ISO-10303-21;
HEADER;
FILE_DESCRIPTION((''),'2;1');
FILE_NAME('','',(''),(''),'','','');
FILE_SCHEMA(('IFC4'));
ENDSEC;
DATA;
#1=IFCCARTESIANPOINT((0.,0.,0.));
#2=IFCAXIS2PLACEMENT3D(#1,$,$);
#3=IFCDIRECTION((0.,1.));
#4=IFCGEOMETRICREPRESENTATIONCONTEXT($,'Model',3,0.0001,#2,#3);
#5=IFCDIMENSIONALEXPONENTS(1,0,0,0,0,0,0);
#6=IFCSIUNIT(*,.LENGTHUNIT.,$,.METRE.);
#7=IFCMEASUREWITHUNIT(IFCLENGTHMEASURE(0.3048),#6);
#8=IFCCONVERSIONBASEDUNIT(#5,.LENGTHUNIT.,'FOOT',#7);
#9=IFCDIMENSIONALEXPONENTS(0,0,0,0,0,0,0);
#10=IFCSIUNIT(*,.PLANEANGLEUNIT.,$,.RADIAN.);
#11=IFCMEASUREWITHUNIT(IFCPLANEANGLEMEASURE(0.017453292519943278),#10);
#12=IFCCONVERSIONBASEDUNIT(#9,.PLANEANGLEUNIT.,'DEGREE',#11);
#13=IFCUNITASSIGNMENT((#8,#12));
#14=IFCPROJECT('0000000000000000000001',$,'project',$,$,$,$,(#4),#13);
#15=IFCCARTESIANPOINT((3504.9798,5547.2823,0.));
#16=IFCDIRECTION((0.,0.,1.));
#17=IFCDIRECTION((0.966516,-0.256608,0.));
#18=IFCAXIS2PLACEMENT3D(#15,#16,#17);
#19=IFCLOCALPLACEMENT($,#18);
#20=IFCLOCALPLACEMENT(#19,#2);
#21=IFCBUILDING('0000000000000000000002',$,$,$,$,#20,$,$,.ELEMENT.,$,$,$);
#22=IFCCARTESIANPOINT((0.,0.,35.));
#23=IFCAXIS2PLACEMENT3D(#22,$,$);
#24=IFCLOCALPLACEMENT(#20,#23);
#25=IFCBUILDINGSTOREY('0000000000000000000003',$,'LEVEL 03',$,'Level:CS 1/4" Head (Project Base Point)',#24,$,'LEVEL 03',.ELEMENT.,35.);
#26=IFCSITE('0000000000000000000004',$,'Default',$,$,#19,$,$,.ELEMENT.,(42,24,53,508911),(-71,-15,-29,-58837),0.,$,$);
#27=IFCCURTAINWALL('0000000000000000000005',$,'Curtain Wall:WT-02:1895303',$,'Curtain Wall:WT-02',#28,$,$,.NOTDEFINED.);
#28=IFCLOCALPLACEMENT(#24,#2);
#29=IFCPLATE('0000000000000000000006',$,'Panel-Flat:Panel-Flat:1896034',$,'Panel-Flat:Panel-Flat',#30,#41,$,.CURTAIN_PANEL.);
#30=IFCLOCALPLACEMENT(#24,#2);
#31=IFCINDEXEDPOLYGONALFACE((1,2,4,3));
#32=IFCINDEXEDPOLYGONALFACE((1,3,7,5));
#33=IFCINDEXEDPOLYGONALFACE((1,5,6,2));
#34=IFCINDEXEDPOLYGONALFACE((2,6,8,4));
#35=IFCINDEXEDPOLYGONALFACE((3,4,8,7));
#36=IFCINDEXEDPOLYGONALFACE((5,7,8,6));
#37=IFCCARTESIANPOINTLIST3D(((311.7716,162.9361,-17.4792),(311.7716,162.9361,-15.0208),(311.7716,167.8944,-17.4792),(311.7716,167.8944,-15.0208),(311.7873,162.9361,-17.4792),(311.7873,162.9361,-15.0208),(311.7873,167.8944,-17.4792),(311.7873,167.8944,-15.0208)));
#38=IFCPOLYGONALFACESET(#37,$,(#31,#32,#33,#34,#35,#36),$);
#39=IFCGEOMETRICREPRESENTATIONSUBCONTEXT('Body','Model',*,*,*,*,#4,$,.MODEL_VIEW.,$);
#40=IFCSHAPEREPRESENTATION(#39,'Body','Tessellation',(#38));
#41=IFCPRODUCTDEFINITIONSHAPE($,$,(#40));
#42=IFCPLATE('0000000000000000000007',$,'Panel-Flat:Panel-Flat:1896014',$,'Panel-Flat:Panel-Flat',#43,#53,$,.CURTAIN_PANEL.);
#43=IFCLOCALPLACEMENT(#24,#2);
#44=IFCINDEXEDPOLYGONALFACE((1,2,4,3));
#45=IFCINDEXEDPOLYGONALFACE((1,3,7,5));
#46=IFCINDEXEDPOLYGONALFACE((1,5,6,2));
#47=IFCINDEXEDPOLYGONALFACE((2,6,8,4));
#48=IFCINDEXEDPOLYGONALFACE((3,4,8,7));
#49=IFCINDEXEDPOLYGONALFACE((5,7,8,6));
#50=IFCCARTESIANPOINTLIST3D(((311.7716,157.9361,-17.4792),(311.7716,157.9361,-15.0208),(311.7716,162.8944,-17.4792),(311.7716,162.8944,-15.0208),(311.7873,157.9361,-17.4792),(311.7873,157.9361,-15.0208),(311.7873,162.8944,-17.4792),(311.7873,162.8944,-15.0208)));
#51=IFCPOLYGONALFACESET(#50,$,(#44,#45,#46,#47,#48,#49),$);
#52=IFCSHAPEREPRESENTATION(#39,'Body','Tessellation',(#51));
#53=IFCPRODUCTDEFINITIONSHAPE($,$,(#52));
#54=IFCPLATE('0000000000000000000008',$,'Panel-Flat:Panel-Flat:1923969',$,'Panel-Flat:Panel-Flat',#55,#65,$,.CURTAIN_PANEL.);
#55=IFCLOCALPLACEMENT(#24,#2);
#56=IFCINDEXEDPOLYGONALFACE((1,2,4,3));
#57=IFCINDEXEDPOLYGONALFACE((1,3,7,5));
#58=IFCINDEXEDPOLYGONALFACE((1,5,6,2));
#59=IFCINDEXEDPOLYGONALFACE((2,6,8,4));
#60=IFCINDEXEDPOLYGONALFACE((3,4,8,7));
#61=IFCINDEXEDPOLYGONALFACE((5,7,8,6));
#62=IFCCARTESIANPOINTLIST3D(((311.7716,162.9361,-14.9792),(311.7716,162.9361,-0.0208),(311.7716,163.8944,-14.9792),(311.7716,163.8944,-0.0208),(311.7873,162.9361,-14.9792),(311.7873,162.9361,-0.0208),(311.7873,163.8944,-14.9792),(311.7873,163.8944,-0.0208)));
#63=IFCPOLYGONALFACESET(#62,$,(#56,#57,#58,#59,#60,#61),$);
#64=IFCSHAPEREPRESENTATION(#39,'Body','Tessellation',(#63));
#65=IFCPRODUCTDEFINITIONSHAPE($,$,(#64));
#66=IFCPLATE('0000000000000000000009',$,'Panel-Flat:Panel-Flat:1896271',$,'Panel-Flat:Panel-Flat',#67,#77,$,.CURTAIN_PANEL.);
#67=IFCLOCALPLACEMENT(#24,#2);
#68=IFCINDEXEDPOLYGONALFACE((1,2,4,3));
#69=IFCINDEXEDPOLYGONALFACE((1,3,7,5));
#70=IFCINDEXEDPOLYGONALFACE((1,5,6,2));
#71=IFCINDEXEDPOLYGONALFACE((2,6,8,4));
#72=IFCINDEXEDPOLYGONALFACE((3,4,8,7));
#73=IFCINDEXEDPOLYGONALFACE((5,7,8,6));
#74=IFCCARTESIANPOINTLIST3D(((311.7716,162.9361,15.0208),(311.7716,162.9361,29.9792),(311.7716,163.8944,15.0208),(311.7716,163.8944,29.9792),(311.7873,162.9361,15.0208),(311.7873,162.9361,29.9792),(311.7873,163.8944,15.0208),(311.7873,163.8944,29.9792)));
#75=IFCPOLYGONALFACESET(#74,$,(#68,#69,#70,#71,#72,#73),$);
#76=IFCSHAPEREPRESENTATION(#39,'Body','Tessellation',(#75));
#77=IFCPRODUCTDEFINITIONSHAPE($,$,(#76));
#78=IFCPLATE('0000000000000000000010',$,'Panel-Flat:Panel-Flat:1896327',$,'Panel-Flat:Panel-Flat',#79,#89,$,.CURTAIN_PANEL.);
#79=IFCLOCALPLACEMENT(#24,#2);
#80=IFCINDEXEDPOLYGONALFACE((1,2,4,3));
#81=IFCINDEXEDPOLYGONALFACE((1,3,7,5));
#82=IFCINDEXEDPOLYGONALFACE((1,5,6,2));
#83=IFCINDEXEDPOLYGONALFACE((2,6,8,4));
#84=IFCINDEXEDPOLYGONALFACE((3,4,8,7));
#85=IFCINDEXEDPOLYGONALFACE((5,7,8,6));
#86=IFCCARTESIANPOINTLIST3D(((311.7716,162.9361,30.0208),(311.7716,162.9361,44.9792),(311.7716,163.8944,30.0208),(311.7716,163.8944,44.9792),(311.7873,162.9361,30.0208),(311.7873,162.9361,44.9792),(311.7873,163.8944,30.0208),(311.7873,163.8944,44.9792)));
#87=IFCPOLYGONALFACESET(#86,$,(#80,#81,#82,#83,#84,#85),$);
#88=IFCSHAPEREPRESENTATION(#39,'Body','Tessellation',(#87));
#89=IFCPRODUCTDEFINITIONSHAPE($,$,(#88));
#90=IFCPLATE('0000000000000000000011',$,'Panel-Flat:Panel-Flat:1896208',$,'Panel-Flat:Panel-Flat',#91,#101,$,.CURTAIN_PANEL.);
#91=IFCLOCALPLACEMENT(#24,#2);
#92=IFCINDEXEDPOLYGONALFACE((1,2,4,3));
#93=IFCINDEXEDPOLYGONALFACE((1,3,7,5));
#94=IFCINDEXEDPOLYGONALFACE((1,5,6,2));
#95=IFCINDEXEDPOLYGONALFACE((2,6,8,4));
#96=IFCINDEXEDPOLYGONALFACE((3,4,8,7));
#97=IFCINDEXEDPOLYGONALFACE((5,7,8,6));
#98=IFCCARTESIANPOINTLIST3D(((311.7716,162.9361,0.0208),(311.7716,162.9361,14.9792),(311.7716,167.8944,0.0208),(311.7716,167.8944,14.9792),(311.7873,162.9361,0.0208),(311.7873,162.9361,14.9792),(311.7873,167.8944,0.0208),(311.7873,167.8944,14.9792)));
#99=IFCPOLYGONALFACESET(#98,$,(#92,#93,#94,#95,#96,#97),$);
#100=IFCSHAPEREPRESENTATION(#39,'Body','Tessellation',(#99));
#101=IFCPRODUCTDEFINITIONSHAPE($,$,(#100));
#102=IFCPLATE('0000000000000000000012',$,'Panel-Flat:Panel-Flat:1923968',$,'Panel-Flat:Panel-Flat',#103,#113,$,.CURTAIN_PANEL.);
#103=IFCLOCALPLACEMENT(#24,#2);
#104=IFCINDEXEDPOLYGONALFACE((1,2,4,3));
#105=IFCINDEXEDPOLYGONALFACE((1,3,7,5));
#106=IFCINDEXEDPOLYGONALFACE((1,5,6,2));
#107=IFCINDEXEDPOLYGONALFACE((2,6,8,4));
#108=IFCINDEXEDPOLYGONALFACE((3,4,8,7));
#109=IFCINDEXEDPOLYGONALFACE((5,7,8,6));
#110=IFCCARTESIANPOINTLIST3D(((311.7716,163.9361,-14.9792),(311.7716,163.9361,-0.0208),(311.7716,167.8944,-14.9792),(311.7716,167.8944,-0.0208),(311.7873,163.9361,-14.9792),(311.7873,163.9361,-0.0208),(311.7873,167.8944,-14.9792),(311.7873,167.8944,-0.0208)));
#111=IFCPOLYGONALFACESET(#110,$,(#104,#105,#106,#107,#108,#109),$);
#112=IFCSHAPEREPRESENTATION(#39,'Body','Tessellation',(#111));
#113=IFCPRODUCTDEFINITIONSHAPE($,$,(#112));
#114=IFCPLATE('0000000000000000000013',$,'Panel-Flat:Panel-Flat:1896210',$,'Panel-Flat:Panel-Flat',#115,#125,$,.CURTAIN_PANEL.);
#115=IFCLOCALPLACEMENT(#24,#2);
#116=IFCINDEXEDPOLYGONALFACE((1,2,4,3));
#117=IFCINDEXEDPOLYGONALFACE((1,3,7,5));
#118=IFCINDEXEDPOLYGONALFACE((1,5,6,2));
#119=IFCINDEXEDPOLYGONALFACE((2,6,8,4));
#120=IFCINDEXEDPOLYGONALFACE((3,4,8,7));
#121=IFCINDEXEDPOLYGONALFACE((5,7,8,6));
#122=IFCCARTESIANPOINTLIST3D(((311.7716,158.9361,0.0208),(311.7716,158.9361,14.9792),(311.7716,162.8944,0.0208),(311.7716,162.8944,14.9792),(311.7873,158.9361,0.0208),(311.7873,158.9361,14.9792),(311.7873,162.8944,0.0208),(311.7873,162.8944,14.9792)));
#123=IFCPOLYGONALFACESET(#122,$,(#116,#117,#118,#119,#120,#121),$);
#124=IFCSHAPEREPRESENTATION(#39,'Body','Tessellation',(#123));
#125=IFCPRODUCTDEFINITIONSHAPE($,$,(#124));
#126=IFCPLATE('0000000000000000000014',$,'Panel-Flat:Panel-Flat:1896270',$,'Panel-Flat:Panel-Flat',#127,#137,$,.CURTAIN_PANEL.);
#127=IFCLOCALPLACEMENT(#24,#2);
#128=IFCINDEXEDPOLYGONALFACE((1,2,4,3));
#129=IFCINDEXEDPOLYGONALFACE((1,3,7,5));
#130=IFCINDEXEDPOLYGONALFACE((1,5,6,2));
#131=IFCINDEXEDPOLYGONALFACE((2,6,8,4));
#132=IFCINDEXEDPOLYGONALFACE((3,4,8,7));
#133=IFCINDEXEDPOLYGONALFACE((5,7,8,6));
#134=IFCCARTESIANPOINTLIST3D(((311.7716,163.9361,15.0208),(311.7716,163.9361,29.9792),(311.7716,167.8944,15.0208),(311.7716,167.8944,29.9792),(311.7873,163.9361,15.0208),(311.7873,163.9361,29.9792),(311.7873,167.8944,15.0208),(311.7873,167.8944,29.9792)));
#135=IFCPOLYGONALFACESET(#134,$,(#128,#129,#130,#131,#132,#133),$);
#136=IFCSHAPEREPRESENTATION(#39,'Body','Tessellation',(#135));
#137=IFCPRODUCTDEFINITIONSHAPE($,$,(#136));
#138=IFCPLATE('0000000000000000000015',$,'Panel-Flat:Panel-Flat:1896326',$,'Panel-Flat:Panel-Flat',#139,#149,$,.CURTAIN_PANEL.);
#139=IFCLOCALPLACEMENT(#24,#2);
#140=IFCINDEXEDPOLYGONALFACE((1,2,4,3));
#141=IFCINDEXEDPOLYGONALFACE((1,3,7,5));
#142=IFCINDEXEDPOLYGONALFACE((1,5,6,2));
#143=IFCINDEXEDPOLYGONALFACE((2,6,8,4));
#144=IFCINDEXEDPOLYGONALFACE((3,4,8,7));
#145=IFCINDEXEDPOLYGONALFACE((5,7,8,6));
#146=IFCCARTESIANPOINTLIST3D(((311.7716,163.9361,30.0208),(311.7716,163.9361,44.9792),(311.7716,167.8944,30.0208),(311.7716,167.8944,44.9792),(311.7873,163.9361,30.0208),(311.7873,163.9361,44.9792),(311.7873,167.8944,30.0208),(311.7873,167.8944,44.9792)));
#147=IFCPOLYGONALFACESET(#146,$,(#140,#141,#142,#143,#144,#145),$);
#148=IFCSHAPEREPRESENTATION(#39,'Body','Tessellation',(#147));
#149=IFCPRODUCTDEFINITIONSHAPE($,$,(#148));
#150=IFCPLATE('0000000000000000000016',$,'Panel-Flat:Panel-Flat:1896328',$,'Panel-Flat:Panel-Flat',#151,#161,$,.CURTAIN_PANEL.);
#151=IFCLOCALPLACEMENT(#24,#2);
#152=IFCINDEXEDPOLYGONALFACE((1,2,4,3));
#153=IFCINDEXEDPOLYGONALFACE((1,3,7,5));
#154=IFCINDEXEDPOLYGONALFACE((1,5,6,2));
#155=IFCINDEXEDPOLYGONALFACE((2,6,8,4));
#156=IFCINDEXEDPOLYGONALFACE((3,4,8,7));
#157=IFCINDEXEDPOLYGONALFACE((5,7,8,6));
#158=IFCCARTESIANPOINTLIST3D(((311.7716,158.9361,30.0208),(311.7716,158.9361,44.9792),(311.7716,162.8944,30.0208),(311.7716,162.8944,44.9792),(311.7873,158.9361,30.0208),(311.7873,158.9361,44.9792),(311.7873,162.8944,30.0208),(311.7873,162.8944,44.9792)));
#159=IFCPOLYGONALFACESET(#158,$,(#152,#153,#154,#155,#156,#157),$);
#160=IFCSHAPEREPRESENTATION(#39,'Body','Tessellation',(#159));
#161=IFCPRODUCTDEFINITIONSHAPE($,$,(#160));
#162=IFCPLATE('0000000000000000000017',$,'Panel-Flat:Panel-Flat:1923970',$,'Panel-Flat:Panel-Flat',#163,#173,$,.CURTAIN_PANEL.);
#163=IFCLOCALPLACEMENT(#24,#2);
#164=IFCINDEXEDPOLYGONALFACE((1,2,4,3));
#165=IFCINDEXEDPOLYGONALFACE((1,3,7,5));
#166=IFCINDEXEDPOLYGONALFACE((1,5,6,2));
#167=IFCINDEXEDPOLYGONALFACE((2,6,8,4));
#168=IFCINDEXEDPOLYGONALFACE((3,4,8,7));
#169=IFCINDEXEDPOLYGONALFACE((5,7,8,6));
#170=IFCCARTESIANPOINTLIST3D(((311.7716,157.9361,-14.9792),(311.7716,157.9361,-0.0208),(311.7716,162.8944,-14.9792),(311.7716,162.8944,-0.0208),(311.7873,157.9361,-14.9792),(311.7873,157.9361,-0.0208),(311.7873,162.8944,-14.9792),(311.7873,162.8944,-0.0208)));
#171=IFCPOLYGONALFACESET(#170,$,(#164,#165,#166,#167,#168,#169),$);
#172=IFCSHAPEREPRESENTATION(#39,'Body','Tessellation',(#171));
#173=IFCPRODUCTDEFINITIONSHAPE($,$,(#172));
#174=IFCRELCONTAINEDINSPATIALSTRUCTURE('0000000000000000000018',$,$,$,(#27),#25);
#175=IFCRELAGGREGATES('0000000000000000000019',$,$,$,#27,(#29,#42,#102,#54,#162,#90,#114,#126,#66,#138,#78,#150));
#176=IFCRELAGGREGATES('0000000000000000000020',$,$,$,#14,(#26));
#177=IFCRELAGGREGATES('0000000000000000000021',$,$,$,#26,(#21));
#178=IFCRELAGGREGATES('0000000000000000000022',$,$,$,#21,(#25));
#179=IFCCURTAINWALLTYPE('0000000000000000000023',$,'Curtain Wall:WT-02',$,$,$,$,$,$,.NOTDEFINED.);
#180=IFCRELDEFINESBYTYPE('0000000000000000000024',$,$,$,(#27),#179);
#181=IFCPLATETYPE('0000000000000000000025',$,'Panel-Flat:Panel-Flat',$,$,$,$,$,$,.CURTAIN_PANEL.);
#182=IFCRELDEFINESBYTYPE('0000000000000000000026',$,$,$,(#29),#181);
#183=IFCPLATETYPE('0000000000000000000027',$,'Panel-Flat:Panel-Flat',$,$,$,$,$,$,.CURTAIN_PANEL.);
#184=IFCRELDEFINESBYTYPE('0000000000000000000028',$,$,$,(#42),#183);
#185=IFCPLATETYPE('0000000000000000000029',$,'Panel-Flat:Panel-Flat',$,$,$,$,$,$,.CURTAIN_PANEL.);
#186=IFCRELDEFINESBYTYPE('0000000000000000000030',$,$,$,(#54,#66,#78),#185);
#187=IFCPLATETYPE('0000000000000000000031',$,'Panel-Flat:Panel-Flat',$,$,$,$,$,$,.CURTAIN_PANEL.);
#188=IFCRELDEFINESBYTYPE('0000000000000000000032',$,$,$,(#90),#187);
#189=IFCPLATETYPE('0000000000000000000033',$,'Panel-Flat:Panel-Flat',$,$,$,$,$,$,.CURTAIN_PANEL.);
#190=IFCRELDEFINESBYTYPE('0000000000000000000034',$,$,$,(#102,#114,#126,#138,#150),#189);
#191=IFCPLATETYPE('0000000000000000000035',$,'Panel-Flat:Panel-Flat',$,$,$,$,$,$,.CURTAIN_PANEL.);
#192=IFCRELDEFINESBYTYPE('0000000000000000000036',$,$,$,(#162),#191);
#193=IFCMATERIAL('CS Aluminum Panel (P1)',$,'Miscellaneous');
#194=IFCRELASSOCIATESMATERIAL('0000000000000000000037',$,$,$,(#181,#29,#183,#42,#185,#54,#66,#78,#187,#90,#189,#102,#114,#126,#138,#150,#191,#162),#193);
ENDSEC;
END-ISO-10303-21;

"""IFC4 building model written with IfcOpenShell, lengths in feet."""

from ifc_helpers import new_model, entity, si_unit, converted_unit, direction, frame, origin, place, context, subcontext, project, spatial, indexed_curve, outline, extrude, source, transform, mapped, material, type_object, type_shapes, element, aggregate, save


model = new_model("IFC4")

# Units and contexts
model_context = context("Model", 3, precision=0.0001, world=origin(), true_north=direction((0.0, 1.0)))
body_context = subcontext(model_context, "Body", "Model", "MODEL_VIEW")
ifc_project = project(units=[converted_unit("LENGTHUNIT", "FOOT", entity("IfcLengthMeasure", 0.3048), si_unit("LENGTHUNIT", "METRE"), dimensions=[1, 0, 0, 0, 0, 0, 0]), converted_unit("PLANEANGLEUNIT", "DEGREE", entity("IfcPlaneAngleMeasure", 0.017453292519943278), si_unit("PLANEANGLEUNIT", "RADIAN"), dimensions=[0, 0, 0, 0, 0, 0, 0])], contexts=[model_context])

# Site, building, storey
site_placement = place(None, frame((3504.9798, 5547.2823, 0.0), z_axis=(0.0, 0.0, 1.0), x_axis=(0.966516, -0.256608, 0.0)))
site = spatial("IfcSite", under=ifc_project, at=site_placement, Name="Default", CompositionType="ELEMENT", RefLatitude=(42, 24, 53, 508911), RefLongitude=(-71, -15, -29, -58837), RefElevation=0.0)
building_placement = place(site_placement, origin())
building = spatial("IfcBuilding", under=site, at=building_placement, CompositionType="ELEMENT")
storey_placement = place(building_placement, frame((0.0, 0.0, 35.0)))
storey = spatial("IfcBuildingStorey", under=building, at=storey_placement, Name="LEVEL 03", ObjectType="Level:CS 1/4\" Head (Project Base Point)", LongName="LEVEL 03", CompositionType="ELEMENT", Elevation=35.0)

# Curtain wall, plates
curtain_wall_type = type_object("IfcCurtainWallType", Name="Curtain Wall:WT-02", PredefinedType="NOTDEFINED")
curtain_wall_placement = place(storey_placement, frame((0.0, 0.0, -35.0)))
curtain_wall = element("IfcCurtainWall", 1, at=curtain_wall_placement, inside=storey, type_object=curtain_wall_type, Name="Curtain Wall:WT-02:1895303", ObjectType="Curtain Wall:WT-02", PredefinedType="NOTDEFINED")
ifc_material_1 = material(Name="CS Aluminum Panel (P1)", Category="Miscellaneous")
plate_type_1 = type_object("IfcPlateType", Name="Panel-Flat:Panel-Flat", PredefinedType="CURTAIN_PANEL", material=ifc_material_1)
shared_shape_1 = source(origin(), body_context, "Body", "SweptSolid", [
    extrude(outline(indexed_curve([(-0.0078, -2.4792), (0.0078, -2.4792), (0.0078, 2.4792), (-0.0078, 2.4792), (-0.0078, -2.4792)], self_intersect=False)), frame((2.4792, 0.0078, 0.0), z_axis=(0.0, 0.0, 1.0), x_axis=(0.0, -1.0, 0.0)), (0.0, 0.0, 1.0), 2.4583),
])
type_shapes(plate_type_1, [shared_shape_1])
plate_1_placement = place(curtain_wall_placement, frame((311.7716, 167.8944, 17.5208), z_axis=(0.0, 0.0, 1.0), x_axis=(0.0, -1.0, 0.0)))
plate_1 = element("IfcPlate", 2, at=plate_1_placement, type_object=plate_type_1, material=ifc_material_1, Name="Panel-Flat:Panel-Flat:1896034", ObjectType="Panel-Flat:Panel-Flat", PredefinedType="CURTAIN_PANEL", context=body_context, shape_type="MappedRepresentation", body=[
    mapped(shared_shape_1, transform((0.0, 0.0, 0.0), scale=1.0)),
])
plate_type_2 = type_object("IfcPlateType", Name="Panel-Flat:Panel-Flat", PredefinedType="CURTAIN_PANEL", material=ifc_material_1)
shared_shape_2 = source(origin(), body_context, "Body", "SweptSolid", [
    extrude(outline(indexed_curve([(-0.0078, -2.4792), (0.0078, -2.4792), (0.0078, 2.4792), (-0.0078, 2.4792), (-0.0078, -2.4792)], self_intersect=False)), frame((2.4792, 0.0078, 0.0), z_axis=(0.0, 0.0, 1.0), x_axis=(0.0, -1.0, 0.0)), (0.0, 0.0, 1.0), 2.4583),
])
type_shapes(plate_type_2, [shared_shape_2])
plate_2_placement = place(curtain_wall_placement, frame((311.7716, 162.8944, 17.5208), z_axis=(0.0, 0.0, 1.0), x_axis=(0.0, -1.0, 0.0)))
plate_2 = element("IfcPlate", 3, at=plate_2_placement, type_object=plate_type_2, material=ifc_material_1, Name="Panel-Flat:Panel-Flat:1896014", ObjectType="Panel-Flat:Panel-Flat", PredefinedType="CURTAIN_PANEL", context=body_context, shape_type="MappedRepresentation", body=[
    mapped(shared_shape_2, transform((0.0, 0.0, 0.0), scale=1.0)),
])
plate_type_3 = type_object("IfcPlateType", Name="Panel-Flat:Panel-Flat", PredefinedType="CURTAIN_PANEL", material=ifc_material_1)
shared_shape_3 = source(origin(), body_context, "Body", "SweptSolid", [
    extrude(outline(indexed_curve([(-0.0078, -0.4792), (0.0078, -0.4792), (0.0078, 0.4792), (-0.0078, 0.4792), (-0.0078, -0.4792)], self_intersect=False)), frame((0.4792, 0.0078, 0.0), z_axis=(0.0, 0.0, 1.0), x_axis=(0.0, -1.0, 0.0)), (0.0, 0.0, 1.0), 14.9583),
])
type_shapes(plate_type_3, [shared_shape_3])
plate_3_placement = place(curtain_wall_placement, frame((311.7716, 163.8944, 20.0208), z_axis=(0.0, 0.0, 1.0), x_axis=(0.0, -1.0, 0.0)))
plate_3 = element("IfcPlate", 4, at=plate_3_placement, type_object=plate_type_3, material=ifc_material_1, Name="Panel-Flat:Panel-Flat:1923969", ObjectType="Panel-Flat:Panel-Flat", PredefinedType="CURTAIN_PANEL", context=body_context, shape_type="MappedRepresentation", body=[
    mapped(shared_shape_3, transform((0.0, 0.0, 0.0), scale=1.0)),
])
plate_4_placement = place(curtain_wall_placement, frame((311.7716, 163.8944, 50.0208), z_axis=(0.0, 0.0, 1.0), x_axis=(0.0, -1.0, 0.0)))
plate_4 = element("IfcPlate", 5, at=plate_4_placement, type_object=plate_type_3, material=ifc_material_1, Name="Panel-Flat:Panel-Flat:1896271", ObjectType="Panel-Flat:Panel-Flat", PredefinedType="CURTAIN_PANEL", context=body_context, shape_type="MappedRepresentation", body=[
    mapped(shared_shape_3, transform((0.0, 0.0, 0.0), scale=1.0)),
])
plate_5_placement = place(curtain_wall_placement, frame((311.7716, 163.8944, 65.0208), z_axis=(0.0, 0.0, 1.0), x_axis=(0.0, -1.0, 0.0)))
plate_5 = element("IfcPlate", 6, at=plate_5_placement, type_object=plate_type_3, material=ifc_material_1, Name="Panel-Flat:Panel-Flat:1896327", ObjectType="Panel-Flat:Panel-Flat", PredefinedType="CURTAIN_PANEL", context=body_context, shape_type="MappedRepresentation", body=[
    mapped(shared_shape_3, transform((0.0, 0.0, 0.0), scale=1.0)),
])
plate_type_4 = type_object("IfcPlateType", Name="Panel-Flat:Panel-Flat", PredefinedType="CURTAIN_PANEL", material=ifc_material_1)
shared_shape_4 = source(origin(), body_context, "Body", "SweptSolid", [
    extrude(outline(indexed_curve([(-0.0078, -2.4792), (0.0078, -2.4792), (0.0078, 2.4792), (-0.0078, 2.4792), (-0.0078, -2.4792)], self_intersect=False)), frame((2.4792, 0.0078, 0.0), z_axis=(0.0, 0.0, 1.0), x_axis=(0.0, -1.0, 0.0)), (0.0, 0.0, 1.0), 14.9583),
])
type_shapes(plate_type_4, [shared_shape_4])
plate_6_placement = place(curtain_wall_placement, frame((311.7716, 167.8944, 35.0208), z_axis=(0.0, 0.0, 1.0), x_axis=(0.0, -1.0, 0.0)))
plate_6 = element("IfcPlate", 7, at=plate_6_placement, type_object=plate_type_4, material=ifc_material_1, Name="Panel-Flat:Panel-Flat:1896208", ObjectType="Panel-Flat:Panel-Flat", PredefinedType="CURTAIN_PANEL", context=body_context, shape_type="MappedRepresentation", body=[
    mapped(shared_shape_4, transform((0.0, 0.0, 0.0), scale=1.0)),
])
plate_type_5 = type_object("IfcPlateType", Name="Panel-Flat:Panel-Flat", PredefinedType="CURTAIN_PANEL", material=ifc_material_1)
shared_shape_5 = source(origin(), body_context, "Body", "SweptSolid", [
    extrude(outline(indexed_curve([(-0.0078, -1.9792), (0.0078, -1.9792), (0.0078, 1.9792), (-0.0078, 1.9792), (-0.0078, -1.9792)], self_intersect=False)), frame((1.9792, 0.0078, 0.0), z_axis=(0.0, 0.0, 1.0), x_axis=(0.0, -1.0, 0.0)), (0.0, 0.0, 1.0), 14.9583),
])
type_shapes(plate_type_5, [shared_shape_5])
plate_7_placement = place(curtain_wall_placement, frame((311.7716, 167.8944, 20.0208), z_axis=(0.0, 0.0, 1.0), x_axis=(0.0, -1.0, 0.0)))
plate_7 = element("IfcPlate", 8, at=plate_7_placement, type_object=plate_type_5, material=ifc_material_1, Name="Panel-Flat:Panel-Flat:1923968", ObjectType="Panel-Flat:Panel-Flat", PredefinedType="CURTAIN_PANEL", context=body_context, shape_type="MappedRepresentation", body=[
    mapped(shared_shape_5, transform((0.0, 0.0, 0.0), scale=1.0)),
])
plate_8_placement = place(curtain_wall_placement, frame((311.7716, 162.8944, 35.0208), z_axis=(0.0, 0.0, 1.0), x_axis=(0.0, -1.0, 0.0)))
plate_8 = element("IfcPlate", 9, at=plate_8_placement, type_object=plate_type_5, material=ifc_material_1, Name="Panel-Flat:Panel-Flat:1896210", ObjectType="Panel-Flat:Panel-Flat", PredefinedType="CURTAIN_PANEL", context=body_context, shape_type="MappedRepresentation", body=[
    mapped(shared_shape_5, transform((0.0, 0.0, 0.0), scale=1.0)),
])
plate_9_placement = place(curtain_wall_placement, frame((311.7716, 167.8944, 50.0208), z_axis=(0.0, 0.0, 1.0), x_axis=(0.0, -1.0, 0.0)))
plate_9 = element("IfcPlate", 10, at=plate_9_placement, type_object=plate_type_5, material=ifc_material_1, Name="Panel-Flat:Panel-Flat:1896270", ObjectType="Panel-Flat:Panel-Flat", PredefinedType="CURTAIN_PANEL", context=body_context, shape_type="MappedRepresentation", body=[
    mapped(shared_shape_5, transform((0.0, 0.0, 0.0), scale=1.0)),
])
plate_10_placement = place(curtain_wall_placement, frame((311.7716, 167.8944, 65.0208), z_axis=(0.0, 0.0, 1.0), x_axis=(0.0, -1.0, 0.0)))
plate_10 = element("IfcPlate", 11, at=plate_10_placement, type_object=plate_type_5, material=ifc_material_1, Name="Panel-Flat:Panel-Flat:1896326", ObjectType="Panel-Flat:Panel-Flat", PredefinedType="CURTAIN_PANEL", context=body_context, shape_type="MappedRepresentation", body=[
    mapped(shared_shape_5, transform((0.0, 0.0, 0.0), scale=1.0)),
])
plate_11_placement = place(curtain_wall_placement, frame((311.7716, 162.8944, 65.0208), z_axis=(0.0, 0.0, 1.0), x_axis=(0.0, -1.0, 0.0)))
plate_11 = element("IfcPlate", 12, at=plate_11_placement, type_object=plate_type_5, material=ifc_material_1, Name="Panel-Flat:Panel-Flat:1896328", ObjectType="Panel-Flat:Panel-Flat", PredefinedType="CURTAIN_PANEL", context=body_context, shape_type="MappedRepresentation", body=[
    mapped(shared_shape_5, transform((0.0, 0.0, 0.0), scale=1.0)),
])
plate_type_6 = type_object("IfcPlateType", Name="Panel-Flat:Panel-Flat", PredefinedType="CURTAIN_PANEL", material=ifc_material_1)
shared_shape_6 = source(origin(), body_context, "Body", "SweptSolid", [
    extrude(outline(indexed_curve([(-0.0078, -2.4792), (0.0078, -2.4792), (0.0078, 2.4792), (-0.0078, 2.4792), (-0.0078, -2.4792)], self_intersect=False)), frame((2.4792, 0.0078, 0.0), z_axis=(0.0, 0.0, 1.0), x_axis=(0.0, -1.0, 0.0)), (0.0, 0.0, 1.0), 14.9583),
])
type_shapes(plate_type_6, [shared_shape_6])
plate_12_placement = place(curtain_wall_placement, frame((311.7716, 162.8944, 20.0208), z_axis=(0.0, 0.0, 1.0), x_axis=(0.0, -1.0, 0.0)))
plate_12 = element("IfcPlate", 13, at=plate_12_placement, type_object=plate_type_6, material=ifc_material_1, Name="Panel-Flat:Panel-Flat:1923970", ObjectType="Panel-Flat:Panel-Flat", PredefinedType="CURTAIN_PANEL", context=body_context, shape_type="MappedRepresentation", body=[
    mapped(shared_shape_6, transform((0.0, 0.0, 0.0), scale=1.0)),
])
aggregate(curtain_wall, [plate_1, plate_2, plate_7, plate_3, plate_12, plate_6, plate_8, plate_9, plate_4, plate_10, plate_5, plate_11])

save(model, "model.ifc")
